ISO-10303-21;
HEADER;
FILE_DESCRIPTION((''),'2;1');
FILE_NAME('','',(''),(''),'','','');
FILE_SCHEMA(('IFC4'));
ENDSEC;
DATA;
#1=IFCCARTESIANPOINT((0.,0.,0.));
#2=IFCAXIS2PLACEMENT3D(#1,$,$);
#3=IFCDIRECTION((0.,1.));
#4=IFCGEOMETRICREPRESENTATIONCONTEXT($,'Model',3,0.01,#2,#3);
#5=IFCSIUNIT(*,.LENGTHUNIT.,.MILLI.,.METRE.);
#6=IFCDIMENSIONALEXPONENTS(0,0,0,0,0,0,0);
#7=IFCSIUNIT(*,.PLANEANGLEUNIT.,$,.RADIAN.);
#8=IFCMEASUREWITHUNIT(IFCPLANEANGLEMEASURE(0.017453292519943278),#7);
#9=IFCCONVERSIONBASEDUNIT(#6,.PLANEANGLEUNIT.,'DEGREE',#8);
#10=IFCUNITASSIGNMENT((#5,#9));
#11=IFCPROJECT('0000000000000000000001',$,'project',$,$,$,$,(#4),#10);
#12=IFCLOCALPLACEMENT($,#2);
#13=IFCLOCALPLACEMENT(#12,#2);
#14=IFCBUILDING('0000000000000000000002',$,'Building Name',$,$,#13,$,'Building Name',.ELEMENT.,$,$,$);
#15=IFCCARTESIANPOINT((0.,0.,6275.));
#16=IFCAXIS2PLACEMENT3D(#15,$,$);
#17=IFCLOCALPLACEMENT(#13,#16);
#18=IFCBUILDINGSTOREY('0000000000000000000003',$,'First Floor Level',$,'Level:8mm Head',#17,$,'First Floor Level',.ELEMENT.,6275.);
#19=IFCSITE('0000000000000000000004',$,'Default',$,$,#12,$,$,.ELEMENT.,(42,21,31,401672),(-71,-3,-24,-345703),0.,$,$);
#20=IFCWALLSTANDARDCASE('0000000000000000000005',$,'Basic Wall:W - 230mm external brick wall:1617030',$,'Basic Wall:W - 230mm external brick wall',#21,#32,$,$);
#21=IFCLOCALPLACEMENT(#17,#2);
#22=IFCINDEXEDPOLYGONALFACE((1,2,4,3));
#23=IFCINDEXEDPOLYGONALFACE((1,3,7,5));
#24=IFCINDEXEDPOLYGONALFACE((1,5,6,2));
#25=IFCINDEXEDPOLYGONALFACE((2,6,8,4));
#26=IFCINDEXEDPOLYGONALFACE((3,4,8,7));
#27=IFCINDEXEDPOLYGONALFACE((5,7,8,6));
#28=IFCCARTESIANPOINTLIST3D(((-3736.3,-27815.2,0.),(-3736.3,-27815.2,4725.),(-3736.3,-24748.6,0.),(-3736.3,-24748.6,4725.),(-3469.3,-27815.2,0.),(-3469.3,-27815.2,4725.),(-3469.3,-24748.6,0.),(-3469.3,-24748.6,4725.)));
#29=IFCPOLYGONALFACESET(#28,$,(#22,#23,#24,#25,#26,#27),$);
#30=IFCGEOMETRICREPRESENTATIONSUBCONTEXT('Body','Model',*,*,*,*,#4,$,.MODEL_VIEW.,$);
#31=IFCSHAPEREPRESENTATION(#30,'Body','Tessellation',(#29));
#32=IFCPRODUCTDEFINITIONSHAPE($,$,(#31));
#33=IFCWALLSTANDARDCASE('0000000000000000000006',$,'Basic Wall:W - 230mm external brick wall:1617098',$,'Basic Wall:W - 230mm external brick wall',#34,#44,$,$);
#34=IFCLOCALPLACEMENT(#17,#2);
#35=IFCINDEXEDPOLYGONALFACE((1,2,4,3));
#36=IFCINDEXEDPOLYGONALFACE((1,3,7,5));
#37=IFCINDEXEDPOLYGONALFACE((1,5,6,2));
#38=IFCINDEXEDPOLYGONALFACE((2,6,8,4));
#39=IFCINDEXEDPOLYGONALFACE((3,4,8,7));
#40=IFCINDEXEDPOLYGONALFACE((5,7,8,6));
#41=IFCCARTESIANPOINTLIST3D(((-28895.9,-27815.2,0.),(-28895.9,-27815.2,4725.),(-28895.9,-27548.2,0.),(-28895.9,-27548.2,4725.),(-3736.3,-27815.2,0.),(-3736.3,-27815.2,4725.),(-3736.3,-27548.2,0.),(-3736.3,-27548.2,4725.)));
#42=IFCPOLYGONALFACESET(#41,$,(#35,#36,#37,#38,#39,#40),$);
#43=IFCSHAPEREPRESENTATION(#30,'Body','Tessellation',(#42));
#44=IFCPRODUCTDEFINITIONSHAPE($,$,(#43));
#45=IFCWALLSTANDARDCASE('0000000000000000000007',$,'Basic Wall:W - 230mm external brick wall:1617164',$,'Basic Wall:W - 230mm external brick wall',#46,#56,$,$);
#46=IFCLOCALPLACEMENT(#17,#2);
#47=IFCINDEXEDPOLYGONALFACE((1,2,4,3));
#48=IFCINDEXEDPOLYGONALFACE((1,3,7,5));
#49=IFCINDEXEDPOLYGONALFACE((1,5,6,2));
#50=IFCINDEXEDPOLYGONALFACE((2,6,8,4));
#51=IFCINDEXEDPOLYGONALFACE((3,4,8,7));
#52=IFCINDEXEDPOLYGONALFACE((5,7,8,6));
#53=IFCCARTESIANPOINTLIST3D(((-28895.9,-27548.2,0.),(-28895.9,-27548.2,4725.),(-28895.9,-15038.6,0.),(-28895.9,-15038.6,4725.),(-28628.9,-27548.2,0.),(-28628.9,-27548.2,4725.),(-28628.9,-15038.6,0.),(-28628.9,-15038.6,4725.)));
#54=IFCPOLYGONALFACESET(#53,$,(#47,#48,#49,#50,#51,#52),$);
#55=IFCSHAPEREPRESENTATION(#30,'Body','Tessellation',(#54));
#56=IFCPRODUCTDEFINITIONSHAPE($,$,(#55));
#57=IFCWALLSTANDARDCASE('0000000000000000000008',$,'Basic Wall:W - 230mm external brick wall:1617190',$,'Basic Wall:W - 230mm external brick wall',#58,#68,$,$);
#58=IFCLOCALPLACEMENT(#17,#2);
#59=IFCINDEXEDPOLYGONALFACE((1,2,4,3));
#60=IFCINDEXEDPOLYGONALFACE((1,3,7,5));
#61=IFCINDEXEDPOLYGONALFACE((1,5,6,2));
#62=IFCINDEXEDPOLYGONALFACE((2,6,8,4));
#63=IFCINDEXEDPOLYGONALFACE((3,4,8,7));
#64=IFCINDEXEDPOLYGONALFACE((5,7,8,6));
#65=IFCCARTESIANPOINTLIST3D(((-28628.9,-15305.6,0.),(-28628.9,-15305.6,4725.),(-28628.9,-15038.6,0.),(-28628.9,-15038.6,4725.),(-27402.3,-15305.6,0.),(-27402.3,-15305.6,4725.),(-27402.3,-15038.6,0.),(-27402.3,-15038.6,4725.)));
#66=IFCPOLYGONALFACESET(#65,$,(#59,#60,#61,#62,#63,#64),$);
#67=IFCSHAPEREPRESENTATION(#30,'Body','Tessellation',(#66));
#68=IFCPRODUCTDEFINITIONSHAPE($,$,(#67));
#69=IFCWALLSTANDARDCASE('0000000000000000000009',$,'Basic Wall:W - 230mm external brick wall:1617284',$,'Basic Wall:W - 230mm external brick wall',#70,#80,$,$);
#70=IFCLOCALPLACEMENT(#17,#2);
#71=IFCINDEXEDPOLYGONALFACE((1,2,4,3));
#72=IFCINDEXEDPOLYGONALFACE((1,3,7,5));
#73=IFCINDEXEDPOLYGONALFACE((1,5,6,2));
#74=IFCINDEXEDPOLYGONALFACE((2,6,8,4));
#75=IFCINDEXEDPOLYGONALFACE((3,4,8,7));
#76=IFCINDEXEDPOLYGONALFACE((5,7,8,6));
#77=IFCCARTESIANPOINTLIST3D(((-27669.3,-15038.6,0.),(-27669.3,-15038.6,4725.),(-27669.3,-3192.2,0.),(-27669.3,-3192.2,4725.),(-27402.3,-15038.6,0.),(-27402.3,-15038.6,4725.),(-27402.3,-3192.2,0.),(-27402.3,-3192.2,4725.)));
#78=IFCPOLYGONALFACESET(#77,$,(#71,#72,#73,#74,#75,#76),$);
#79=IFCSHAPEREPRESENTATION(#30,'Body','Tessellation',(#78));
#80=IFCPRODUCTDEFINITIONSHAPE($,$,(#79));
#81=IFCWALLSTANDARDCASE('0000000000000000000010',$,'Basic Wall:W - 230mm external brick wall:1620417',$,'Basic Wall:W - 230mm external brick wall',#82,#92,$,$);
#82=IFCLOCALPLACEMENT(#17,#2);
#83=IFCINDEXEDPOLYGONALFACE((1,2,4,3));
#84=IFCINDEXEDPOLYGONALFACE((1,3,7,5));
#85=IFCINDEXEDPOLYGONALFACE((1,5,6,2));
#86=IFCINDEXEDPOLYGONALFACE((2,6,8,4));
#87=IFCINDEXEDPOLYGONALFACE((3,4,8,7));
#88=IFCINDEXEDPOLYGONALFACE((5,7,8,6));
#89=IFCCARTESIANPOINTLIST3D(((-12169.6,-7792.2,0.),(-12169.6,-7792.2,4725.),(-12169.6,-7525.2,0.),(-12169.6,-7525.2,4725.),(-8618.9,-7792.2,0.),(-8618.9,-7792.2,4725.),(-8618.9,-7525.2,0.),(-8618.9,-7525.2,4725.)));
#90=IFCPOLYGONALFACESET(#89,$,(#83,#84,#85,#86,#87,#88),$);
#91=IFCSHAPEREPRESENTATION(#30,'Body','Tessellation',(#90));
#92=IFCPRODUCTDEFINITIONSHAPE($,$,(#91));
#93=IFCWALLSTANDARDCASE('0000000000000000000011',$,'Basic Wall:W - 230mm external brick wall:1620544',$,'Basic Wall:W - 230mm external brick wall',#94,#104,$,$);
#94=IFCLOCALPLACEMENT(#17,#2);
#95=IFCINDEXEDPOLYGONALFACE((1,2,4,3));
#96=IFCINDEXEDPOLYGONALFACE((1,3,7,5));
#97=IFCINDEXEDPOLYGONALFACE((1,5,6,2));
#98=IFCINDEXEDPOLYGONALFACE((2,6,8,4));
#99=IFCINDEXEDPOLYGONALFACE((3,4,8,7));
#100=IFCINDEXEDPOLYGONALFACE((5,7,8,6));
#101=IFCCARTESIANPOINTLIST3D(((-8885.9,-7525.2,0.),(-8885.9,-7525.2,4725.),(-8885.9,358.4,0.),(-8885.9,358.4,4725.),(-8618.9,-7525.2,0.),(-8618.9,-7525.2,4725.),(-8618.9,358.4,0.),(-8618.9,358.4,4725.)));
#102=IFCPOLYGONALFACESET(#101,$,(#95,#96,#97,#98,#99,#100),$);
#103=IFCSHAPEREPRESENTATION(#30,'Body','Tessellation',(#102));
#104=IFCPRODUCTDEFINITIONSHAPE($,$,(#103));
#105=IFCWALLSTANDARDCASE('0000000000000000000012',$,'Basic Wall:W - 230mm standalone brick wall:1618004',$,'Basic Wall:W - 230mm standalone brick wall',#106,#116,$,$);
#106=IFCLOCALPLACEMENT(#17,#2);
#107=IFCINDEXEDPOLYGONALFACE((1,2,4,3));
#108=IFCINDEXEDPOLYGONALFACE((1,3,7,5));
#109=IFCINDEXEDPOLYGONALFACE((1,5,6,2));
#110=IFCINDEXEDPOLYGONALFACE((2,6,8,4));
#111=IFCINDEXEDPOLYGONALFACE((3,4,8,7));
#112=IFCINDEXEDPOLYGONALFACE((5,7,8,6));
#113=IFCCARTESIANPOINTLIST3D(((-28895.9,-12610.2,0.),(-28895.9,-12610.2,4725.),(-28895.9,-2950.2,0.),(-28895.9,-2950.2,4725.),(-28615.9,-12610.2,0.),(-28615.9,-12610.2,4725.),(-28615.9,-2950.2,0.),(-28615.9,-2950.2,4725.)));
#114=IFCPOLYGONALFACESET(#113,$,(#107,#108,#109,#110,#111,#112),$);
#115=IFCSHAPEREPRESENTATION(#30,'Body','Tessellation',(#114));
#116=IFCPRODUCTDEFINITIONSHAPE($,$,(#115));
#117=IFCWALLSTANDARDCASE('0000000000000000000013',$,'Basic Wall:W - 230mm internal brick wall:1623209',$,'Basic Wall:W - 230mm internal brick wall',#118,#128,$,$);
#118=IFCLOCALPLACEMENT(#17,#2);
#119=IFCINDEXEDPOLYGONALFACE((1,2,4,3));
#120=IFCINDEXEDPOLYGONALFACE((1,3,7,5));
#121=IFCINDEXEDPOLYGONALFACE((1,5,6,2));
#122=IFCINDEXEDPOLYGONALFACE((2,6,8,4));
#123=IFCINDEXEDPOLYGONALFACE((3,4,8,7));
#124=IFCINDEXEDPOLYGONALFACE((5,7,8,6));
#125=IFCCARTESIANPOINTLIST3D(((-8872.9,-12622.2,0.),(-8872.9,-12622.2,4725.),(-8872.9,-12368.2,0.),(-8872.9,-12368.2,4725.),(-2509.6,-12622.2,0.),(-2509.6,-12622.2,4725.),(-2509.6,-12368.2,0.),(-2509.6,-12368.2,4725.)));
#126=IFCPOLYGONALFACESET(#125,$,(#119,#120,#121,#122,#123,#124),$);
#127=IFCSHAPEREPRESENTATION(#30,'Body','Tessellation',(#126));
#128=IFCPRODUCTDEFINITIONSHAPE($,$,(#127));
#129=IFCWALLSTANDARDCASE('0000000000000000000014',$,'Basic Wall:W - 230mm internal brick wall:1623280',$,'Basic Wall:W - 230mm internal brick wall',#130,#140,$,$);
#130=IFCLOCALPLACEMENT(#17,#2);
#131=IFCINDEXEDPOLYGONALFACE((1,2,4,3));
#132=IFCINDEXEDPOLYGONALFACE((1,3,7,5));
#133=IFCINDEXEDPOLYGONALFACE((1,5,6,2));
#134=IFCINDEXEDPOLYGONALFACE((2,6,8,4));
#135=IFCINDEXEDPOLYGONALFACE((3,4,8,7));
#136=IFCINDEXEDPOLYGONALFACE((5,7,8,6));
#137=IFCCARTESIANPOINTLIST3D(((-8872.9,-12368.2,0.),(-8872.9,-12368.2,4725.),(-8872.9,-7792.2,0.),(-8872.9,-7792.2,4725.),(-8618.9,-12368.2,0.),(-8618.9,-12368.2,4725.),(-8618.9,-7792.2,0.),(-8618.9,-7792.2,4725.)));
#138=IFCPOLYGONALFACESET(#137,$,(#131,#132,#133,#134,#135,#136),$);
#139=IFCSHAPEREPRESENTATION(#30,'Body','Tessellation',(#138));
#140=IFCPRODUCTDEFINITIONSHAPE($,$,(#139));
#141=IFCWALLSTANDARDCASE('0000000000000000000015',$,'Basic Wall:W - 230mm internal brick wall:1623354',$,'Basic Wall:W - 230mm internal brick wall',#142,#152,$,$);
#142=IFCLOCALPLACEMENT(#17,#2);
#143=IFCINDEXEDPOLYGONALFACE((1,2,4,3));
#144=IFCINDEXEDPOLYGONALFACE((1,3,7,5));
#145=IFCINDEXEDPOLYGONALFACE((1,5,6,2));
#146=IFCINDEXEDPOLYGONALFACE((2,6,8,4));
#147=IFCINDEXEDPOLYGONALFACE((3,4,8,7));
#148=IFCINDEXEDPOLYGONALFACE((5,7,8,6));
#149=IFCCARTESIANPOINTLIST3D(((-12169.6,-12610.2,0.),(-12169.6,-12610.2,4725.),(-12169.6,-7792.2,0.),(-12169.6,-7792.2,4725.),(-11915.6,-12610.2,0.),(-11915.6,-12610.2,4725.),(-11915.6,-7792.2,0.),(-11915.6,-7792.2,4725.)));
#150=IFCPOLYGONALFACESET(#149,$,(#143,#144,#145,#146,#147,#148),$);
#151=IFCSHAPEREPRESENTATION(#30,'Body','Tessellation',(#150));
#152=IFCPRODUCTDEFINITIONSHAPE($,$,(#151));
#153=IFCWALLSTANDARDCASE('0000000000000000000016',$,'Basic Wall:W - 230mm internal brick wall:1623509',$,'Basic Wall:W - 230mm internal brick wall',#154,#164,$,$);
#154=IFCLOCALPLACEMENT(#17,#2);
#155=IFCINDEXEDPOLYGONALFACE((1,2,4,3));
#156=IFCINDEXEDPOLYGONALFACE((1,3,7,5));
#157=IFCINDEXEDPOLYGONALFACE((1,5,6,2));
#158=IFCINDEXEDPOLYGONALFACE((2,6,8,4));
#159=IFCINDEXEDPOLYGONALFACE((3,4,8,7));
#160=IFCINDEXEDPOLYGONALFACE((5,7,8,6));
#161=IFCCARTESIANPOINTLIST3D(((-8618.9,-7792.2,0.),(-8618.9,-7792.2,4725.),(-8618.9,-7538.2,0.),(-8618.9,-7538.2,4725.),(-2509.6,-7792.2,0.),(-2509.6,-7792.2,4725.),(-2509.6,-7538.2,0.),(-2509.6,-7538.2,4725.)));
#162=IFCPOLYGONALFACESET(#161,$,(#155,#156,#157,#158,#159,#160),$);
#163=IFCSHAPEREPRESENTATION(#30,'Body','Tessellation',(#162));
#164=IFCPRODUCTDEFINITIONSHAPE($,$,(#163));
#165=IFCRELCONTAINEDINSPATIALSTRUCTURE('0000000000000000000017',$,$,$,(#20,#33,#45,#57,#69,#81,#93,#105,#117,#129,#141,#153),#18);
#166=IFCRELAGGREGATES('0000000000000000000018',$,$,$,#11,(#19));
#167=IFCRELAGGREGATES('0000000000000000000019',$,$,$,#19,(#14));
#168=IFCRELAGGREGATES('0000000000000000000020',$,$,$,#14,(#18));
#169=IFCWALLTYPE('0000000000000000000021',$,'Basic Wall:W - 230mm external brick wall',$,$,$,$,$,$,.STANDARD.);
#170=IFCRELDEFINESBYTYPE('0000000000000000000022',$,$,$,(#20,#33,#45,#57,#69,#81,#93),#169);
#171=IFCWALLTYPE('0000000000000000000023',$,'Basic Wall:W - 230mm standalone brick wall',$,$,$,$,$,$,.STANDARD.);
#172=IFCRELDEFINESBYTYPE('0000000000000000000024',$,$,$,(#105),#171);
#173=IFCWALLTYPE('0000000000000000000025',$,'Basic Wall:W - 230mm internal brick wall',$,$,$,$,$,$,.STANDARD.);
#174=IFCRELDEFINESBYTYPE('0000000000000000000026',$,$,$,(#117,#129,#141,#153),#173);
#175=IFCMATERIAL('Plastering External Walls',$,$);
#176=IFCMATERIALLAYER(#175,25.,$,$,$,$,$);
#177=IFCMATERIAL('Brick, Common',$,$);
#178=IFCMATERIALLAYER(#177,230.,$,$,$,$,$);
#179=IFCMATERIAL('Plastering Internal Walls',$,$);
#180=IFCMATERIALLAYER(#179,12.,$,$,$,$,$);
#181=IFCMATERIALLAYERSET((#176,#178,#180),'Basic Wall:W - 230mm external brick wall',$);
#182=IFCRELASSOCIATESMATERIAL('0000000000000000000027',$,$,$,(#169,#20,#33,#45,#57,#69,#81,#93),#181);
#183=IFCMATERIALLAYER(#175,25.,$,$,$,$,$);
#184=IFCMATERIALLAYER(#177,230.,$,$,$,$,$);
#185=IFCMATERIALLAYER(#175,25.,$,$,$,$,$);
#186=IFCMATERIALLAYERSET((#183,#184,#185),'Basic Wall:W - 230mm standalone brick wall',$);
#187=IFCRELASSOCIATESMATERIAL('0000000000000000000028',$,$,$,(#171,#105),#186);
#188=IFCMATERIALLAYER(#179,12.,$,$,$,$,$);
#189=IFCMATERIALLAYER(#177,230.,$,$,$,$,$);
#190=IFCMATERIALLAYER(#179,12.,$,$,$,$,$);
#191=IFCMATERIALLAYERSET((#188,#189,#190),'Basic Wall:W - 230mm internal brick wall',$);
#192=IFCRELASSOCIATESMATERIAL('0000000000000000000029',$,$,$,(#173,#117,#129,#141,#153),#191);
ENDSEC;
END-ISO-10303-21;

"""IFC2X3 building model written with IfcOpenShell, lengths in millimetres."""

from ifc_helpers import new_model, entity, si_unit, converted_unit, direction, frame, frame_2d, origin, place, context, subcontext, project, spatial, rectangle, extrude, material, layer, layer_set, layer_usage, type_object, element, save


model = new_model("IFC2X3")

# Units and contexts
model_context = context("Model", 3, precision=0.01, world=origin(), true_north=direction((0.0, 1.0)))
body_context = subcontext(model_context, "Body", "Model", "MODEL_VIEW")
ifc_project = project(units=[si_unit("LENGTHUNIT", "METRE", prefix="MILLI"), converted_unit("PLANEANGLEUNIT", "DEGREE", entity("IfcPlaneAngleMeasure", 0.017453292519943278), si_unit("PLANEANGLEUNIT", "RADIAN"), dimensions=[0, 0, 0, 0, 0, 0, 0])], contexts=[model_context])

# Site, building, storey
site_placement = place(None, origin())
site = spatial("IfcSite", under=ifc_project, at=site_placement, Name="Default", CompositionType="ELEMENT", RefLatitude=(42, 21, 31, 401672), RefLongitude=(-71, -3, -24, -345703), RefElevation=0.0)
building_placement = place(site_placement, origin())
building = spatial("IfcBuilding", under=site, at=building_placement, Name="Building Name", LongName="Building Name", CompositionType="ELEMENT")
storey_placement = place(building_placement, frame((0.0, 0.0, 6275.0)))
storey = spatial("IfcBuildingStorey", under=building, at=storey_placement, Name="First Floor Level", ObjectType="Level:8mm Head", LongName="First Floor Level", CompositionType="ELEMENT", Elevation=6275.0)

# Walls
ifc_material_1 = material(Name="Plastering External Walls")
ifc_layer_1 = layer(ifc_material_1, 25.0)
ifc_material_2 = material(Name="Brick, Common")
ifc_layer_2 = layer(ifc_material_2, 230.0)
ifc_material_3 = material(Name="Plastering Internal Walls")
ifc_layer_3 = layer(ifc_material_3, 12.0)
ifc_layer_set_1 = layer_set([ifc_layer_1, ifc_layer_2, ifc_layer_3], Name="Basic Wall:W - 230mm external brick wall")
ifc_layer_usage_1 = layer_usage(ifc_layer_set_1, "AXIS2", "NEGATIVE", 133.5)
wall_type_1 = type_object("IfcWallType", Name="Basic Wall:W - 230mm external brick wall", PredefinedType="STANDARD", material=ifc_layer_set_1)
wall_1_placement = place(storey_placement, frame((-3602.8, -24748.6, 0.0), z_axis=(0.0, 0.0, 1.0), x_axis=(0.0, -1.0, 0.0)))
element("IfcWallStandardCase", 1, at=wall_1_placement, inside=storey, type_object=wall_type_1, material=ifc_layer_usage_1, Name="Basic Wall:W - 230mm external brick wall:1617030", ObjectType="Basic Wall:W - 230mm external brick wall", context=body_context, shape_type="SweptSolid", body=[
    extrude(rectangle(XDim=3066.7, YDim=267.0, at=frame_2d((1533.3, 0.0), x_axis=(-1.0, 0.0))), origin(), (0.0, 0.0, 1.0), 4725.0),
])
ifc_layer_usage_2 = layer_usage(ifc_layer_set_1, "AXIS2", "NEGATIVE", 133.5)
wall_2_placement = place(storey_placement, frame((-3736.3, -27681.7, 0.0), z_axis=(0.0, 0.0, 1.0), x_axis=(-1.0, 0.0, 0.0)))
element("IfcWallStandardCase", 2, at=wall_2_placement, inside=storey, type_object=wall_type_1, material=ifc_layer_usage_2, Name="Basic Wall:W - 230mm external brick wall:1617098", ObjectType="Basic Wall:W - 230mm external brick wall", context=body_context, shape_type="SweptSolid", body=[
    extrude(rectangle(XDim=25159.7, YDim=267.0, at=frame_2d((12579.8, 0.0), x_axis=(-1.0, 0.0))), origin(), (0.0, 0.0, 1.0), 4725.0),
])
ifc_layer_usage_3 = layer_usage(ifc_layer_set_1, "AXIS2", "NEGATIVE", 133.5)
wall_3_placement = place(storey_placement, frame((-28762.4, -27548.2, 0.0), z_axis=(0.0, 0.0, 1.0), x_axis=(0.0, 1.0, 0.0)))
element("IfcWallStandardCase", 3, at=wall_3_placement, inside=storey, type_object=wall_type_1, material=ifc_layer_usage_3, Name="Basic Wall:W - 230mm external brick wall:1617164", ObjectType="Basic Wall:W - 230mm external brick wall", context=body_context, shape_type="SweptSolid", body=[
    extrude(rectangle(XDim=12509.7, YDim=267.0, at=frame_2d((6254.8, 0.0), x_axis=(-1.0, 0.0))), origin(), (0.0, 0.0, 1.0), 4725.0),
])
ifc_layer_usage_4 = layer_usage(ifc_layer_set_1, "AXIS2", "NEGATIVE", 133.5)
wall_4_placement = place(storey_placement, frame((-28628.9, -15172.1, 0.0)))
element("IfcWallStandardCase", 4, at=wall_4_placement, inside=storey, type_object=wall_type_1, material=ifc_layer_usage_4, Name="Basic Wall:W - 230mm external brick wall:1617190", ObjectType="Basic Wall:W - 230mm external brick wall", context=body_context, shape_type="SweptSolid", body=[
    extrude(rectangle(XDim=1226.7, YDim=267.0, at=frame_2d((613.3, 0.0), x_axis=(-1.0, 0.0))), origin(), (0.0, 0.0, 1.0), 4725.0),
])
ifc_layer_usage_5 = layer_usage(ifc_layer_set_1, "AXIS2", "NEGATIVE", 133.5)
wall_5_placement = place(storey_placement, frame((-27535.8, -15038.6, 0.0), z_axis=(0.0, 0.0, 1.0), x_axis=(0.0, 1.0, 0.0)))
element("IfcWallStandardCase", 5, at=wall_5_placement, inside=storey, type_object=wall_type_1, material=ifc_layer_usage_5, Name="Basic Wall:W - 230mm external brick wall:1617284", ObjectType="Basic Wall:W - 230mm external brick wall", context=body_context, shape_type="SweptSolid", body=[
    extrude(rectangle(XDim=11846.3, YDim=267.0, at=frame_2d((5923.2, 0.0), x_axis=(-1.0, 0.0))), origin(), (0.0, 0.0, 1.0), 4725.0),
])
ifc_layer_usage_6 = layer_usage(ifc_layer_set_1, "AXIS2", "NEGATIVE", 133.5)
wall_6_placement = place(storey_placement, frame((-12169.6, -7658.7, 0.0)))
element("IfcWallStandardCase", 6, at=wall_6_placement, inside=storey, type_object=wall_type_1, material=ifc_layer_usage_6, Name="Basic Wall:W - 230mm external brick wall:1620417", ObjectType="Basic Wall:W - 230mm external brick wall", context=body_context, shape_type="SweptSolid", body=[
    extrude(rectangle(XDim=3550.7, YDim=267.0, at=frame_2d((1775.3, 0.0), x_axis=(-1.0, 0.0))), origin(), (0.0, 0.0, 1.0), 4725.0),
])
ifc_layer_usage_7 = layer_usage(ifc_layer_set_1, "AXIS2", "NEGATIVE", 133.5)
wall_7_placement = place(storey_placement, frame((-8752.4, -7525.2, 0.0), z_axis=(0.0, 0.0, 1.0), x_axis=(0.0, 1.0, 0.0)))
element("IfcWallStandardCase", 7, at=wall_7_placement, inside=storey, type_object=wall_type_1, material=ifc_layer_usage_7, Name="Basic Wall:W - 230mm external brick wall:1620544", ObjectType="Basic Wall:W - 230mm external brick wall", context=body_context, shape_type="SweptSolid", body=[
    extrude(rectangle(XDim=7883.7, YDim=267.0, at=frame_2d((3941.8, 0.0), x_axis=(-1.0, 0.0))), origin(), (0.0, 0.0, 1.0), 4725.0),
])
ifc_layer_4 = layer(ifc_material_1, 25.0)
ifc_layer_5 = layer(ifc_material_2, 230.0)
ifc_layer_6 = layer(ifc_material_1, 25.0)
ifc_layer_set_2 = layer_set([ifc_layer_4, ifc_layer_5, ifc_layer_6], Name="Basic Wall:W - 230mm standalone brick wall")
ifc_layer_usage_8 = layer_usage(ifc_layer_set_2, "AXIS2", "NEGATIVE", 140.0)
wall_type_2 = type_object("IfcWallType", Name="Basic Wall:W - 230mm standalone brick wall", PredefinedType="STANDARD", material=ifc_layer_set_2)
wall_8_placement = place(storey_placement, frame((-28755.9, -12610.2, 0.0), z_axis=(0.0, 0.0, 1.0), x_axis=(0.0, 1.0, 0.0)))
element("IfcWallStandardCase", 8, at=wall_8_placement, inside=storey, type_object=wall_type_2, material=ifc_layer_usage_8, Name="Basic Wall:W - 230mm standalone brick wall:1618004", ObjectType="Basic Wall:W - 230mm standalone brick wall", context=body_context, shape_type="SweptSolid", body=[
    extrude(rectangle(XDim=9660.0, YDim=280.0, at=frame_2d((4830.0, 0.0), x_axis=(-1.0, 0.0))), origin(), (0.0, 0.0, 1.0), 4725.0),
])
ifc_layer_7 = layer(ifc_material_3, 12.0)
ifc_layer_8 = layer(ifc_material_2, 230.0)
ifc_layer_9 = layer(ifc_material_3, 12.0)
ifc_layer_set_3 = layer_set([ifc_layer_7, ifc_layer_8, ifc_layer_9], Name="Basic Wall:W - 230mm internal brick wall")
ifc_layer_usage_9 = layer_usage(ifc_layer_set_3, "AXIS2", "NEGATIVE", 127.0)
wall_type_3 = type_object("IfcWallType", Name="Basic Wall:W - 230mm internal brick wall", PredefinedType="STANDARD", material=ifc_layer_set_3)
wall_9_placement = place(storey_placement, frame((-2509.6, -12495.2, 0.0), z_axis=(0.0, 0.0, 1.0), x_axis=(-1.0, 0.0, 0.0)))
element("IfcWallStandardCase", 9, at=wall_9_placement, inside=storey, type_object=wall_type_3, material=ifc_layer_usage_9, Name="Basic Wall:W - 230mm internal brick wall:1623209", ObjectType="Basic Wall:W - 230mm internal brick wall", context=body_context, shape_type="SweptSolid", body=[
    extrude(rectangle(XDim=6363.3, YDim=254.0, at=frame_2d((3181.7, 0.0), x_axis=(-1.0, 0.0))), origin(), (0.0, 0.0, 1.0), 4725.0),
])
ifc_layer_usage_10 = layer_usage(ifc_layer_set_3, "AXIS2", "NEGATIVE", 127.0)
wall_10_placement = place(storey_placement, frame((-8745.9, -12368.2, 0.0), z_axis=(0.0, 0.0, 1.0), x_axis=(0.0, 1.0, 0.0)))
element("IfcWallStandardCase", 10, at=wall_10_placement, inside=storey, type_object=wall_type_3, material=ifc_layer_usage_10, Name="Basic Wall:W - 230mm internal brick wall:1623280", ObjectType="Basic Wall:W - 230mm internal brick wall", context=body_context, shape_type="SweptSolid", body=[
    extrude(rectangle(XDim=4576.0, YDim=254.0, at=frame_2d((2288.0, 0.0), x_axis=(-1.0, 0.0))), origin(), (0.0, 0.0, 1.0), 4725.0),
])
ifc_layer_usage_11 = layer_usage(ifc_layer_set_3, "AXIS2", "NEGATIVE", 127.0)
wall_11_placement = place(storey_placement, frame((-12042.6, -7792.2, 0.0), z_axis=(0.0, 0.0, 1.0), x_axis=(0.0, -1.0, 0.0)))
element("IfcWallStandardCase", 11, at=wall_11_placement, inside=storey, type_object=wall_type_3, material=ifc_layer_usage_11, Name="Basic Wall:W - 230mm internal brick wall:1623354", ObjectType="Basic Wall:W - 230mm internal brick wall", context=body_context, shape_type="SweptSolid", body=[
    extrude(rectangle(XDim=4818.0, YDim=254.0, at=frame_2d((2409.0, 0.0), x_axis=(-1.0, 0.0))), origin(), (0.0, 0.0, 1.0), 4725.0),
])
ifc_layer_usage_12 = layer_usage(ifc_layer_set_3, "AXIS2", "NEGATIVE", 127.0)
wall_12_placement = place(storey_placement, frame((-2509.6, -7665.2, 0.0), z_axis=(0.0, 0.0, 1.0), x_axis=(-1.0, 0.0, 0.0)))
element("IfcWallStandardCase", 12, at=wall_12_placement, inside=storey, type_object=wall_type_3, material=ifc_layer_usage_12, Name="Basic Wall:W - 230mm internal brick wall:1623509", ObjectType="Basic Wall:W - 230mm internal brick wall", context=body_context, shape_type="SweptSolid", body=[
    extrude(rectangle(XDim=6109.3, YDim=254.0, at=frame_2d((3054.7, 0.0), x_axis=(-1.0, 0.0))), origin(), (0.0, 0.0, 1.0), 4725.0),
])

save(model, "model.ifc")
